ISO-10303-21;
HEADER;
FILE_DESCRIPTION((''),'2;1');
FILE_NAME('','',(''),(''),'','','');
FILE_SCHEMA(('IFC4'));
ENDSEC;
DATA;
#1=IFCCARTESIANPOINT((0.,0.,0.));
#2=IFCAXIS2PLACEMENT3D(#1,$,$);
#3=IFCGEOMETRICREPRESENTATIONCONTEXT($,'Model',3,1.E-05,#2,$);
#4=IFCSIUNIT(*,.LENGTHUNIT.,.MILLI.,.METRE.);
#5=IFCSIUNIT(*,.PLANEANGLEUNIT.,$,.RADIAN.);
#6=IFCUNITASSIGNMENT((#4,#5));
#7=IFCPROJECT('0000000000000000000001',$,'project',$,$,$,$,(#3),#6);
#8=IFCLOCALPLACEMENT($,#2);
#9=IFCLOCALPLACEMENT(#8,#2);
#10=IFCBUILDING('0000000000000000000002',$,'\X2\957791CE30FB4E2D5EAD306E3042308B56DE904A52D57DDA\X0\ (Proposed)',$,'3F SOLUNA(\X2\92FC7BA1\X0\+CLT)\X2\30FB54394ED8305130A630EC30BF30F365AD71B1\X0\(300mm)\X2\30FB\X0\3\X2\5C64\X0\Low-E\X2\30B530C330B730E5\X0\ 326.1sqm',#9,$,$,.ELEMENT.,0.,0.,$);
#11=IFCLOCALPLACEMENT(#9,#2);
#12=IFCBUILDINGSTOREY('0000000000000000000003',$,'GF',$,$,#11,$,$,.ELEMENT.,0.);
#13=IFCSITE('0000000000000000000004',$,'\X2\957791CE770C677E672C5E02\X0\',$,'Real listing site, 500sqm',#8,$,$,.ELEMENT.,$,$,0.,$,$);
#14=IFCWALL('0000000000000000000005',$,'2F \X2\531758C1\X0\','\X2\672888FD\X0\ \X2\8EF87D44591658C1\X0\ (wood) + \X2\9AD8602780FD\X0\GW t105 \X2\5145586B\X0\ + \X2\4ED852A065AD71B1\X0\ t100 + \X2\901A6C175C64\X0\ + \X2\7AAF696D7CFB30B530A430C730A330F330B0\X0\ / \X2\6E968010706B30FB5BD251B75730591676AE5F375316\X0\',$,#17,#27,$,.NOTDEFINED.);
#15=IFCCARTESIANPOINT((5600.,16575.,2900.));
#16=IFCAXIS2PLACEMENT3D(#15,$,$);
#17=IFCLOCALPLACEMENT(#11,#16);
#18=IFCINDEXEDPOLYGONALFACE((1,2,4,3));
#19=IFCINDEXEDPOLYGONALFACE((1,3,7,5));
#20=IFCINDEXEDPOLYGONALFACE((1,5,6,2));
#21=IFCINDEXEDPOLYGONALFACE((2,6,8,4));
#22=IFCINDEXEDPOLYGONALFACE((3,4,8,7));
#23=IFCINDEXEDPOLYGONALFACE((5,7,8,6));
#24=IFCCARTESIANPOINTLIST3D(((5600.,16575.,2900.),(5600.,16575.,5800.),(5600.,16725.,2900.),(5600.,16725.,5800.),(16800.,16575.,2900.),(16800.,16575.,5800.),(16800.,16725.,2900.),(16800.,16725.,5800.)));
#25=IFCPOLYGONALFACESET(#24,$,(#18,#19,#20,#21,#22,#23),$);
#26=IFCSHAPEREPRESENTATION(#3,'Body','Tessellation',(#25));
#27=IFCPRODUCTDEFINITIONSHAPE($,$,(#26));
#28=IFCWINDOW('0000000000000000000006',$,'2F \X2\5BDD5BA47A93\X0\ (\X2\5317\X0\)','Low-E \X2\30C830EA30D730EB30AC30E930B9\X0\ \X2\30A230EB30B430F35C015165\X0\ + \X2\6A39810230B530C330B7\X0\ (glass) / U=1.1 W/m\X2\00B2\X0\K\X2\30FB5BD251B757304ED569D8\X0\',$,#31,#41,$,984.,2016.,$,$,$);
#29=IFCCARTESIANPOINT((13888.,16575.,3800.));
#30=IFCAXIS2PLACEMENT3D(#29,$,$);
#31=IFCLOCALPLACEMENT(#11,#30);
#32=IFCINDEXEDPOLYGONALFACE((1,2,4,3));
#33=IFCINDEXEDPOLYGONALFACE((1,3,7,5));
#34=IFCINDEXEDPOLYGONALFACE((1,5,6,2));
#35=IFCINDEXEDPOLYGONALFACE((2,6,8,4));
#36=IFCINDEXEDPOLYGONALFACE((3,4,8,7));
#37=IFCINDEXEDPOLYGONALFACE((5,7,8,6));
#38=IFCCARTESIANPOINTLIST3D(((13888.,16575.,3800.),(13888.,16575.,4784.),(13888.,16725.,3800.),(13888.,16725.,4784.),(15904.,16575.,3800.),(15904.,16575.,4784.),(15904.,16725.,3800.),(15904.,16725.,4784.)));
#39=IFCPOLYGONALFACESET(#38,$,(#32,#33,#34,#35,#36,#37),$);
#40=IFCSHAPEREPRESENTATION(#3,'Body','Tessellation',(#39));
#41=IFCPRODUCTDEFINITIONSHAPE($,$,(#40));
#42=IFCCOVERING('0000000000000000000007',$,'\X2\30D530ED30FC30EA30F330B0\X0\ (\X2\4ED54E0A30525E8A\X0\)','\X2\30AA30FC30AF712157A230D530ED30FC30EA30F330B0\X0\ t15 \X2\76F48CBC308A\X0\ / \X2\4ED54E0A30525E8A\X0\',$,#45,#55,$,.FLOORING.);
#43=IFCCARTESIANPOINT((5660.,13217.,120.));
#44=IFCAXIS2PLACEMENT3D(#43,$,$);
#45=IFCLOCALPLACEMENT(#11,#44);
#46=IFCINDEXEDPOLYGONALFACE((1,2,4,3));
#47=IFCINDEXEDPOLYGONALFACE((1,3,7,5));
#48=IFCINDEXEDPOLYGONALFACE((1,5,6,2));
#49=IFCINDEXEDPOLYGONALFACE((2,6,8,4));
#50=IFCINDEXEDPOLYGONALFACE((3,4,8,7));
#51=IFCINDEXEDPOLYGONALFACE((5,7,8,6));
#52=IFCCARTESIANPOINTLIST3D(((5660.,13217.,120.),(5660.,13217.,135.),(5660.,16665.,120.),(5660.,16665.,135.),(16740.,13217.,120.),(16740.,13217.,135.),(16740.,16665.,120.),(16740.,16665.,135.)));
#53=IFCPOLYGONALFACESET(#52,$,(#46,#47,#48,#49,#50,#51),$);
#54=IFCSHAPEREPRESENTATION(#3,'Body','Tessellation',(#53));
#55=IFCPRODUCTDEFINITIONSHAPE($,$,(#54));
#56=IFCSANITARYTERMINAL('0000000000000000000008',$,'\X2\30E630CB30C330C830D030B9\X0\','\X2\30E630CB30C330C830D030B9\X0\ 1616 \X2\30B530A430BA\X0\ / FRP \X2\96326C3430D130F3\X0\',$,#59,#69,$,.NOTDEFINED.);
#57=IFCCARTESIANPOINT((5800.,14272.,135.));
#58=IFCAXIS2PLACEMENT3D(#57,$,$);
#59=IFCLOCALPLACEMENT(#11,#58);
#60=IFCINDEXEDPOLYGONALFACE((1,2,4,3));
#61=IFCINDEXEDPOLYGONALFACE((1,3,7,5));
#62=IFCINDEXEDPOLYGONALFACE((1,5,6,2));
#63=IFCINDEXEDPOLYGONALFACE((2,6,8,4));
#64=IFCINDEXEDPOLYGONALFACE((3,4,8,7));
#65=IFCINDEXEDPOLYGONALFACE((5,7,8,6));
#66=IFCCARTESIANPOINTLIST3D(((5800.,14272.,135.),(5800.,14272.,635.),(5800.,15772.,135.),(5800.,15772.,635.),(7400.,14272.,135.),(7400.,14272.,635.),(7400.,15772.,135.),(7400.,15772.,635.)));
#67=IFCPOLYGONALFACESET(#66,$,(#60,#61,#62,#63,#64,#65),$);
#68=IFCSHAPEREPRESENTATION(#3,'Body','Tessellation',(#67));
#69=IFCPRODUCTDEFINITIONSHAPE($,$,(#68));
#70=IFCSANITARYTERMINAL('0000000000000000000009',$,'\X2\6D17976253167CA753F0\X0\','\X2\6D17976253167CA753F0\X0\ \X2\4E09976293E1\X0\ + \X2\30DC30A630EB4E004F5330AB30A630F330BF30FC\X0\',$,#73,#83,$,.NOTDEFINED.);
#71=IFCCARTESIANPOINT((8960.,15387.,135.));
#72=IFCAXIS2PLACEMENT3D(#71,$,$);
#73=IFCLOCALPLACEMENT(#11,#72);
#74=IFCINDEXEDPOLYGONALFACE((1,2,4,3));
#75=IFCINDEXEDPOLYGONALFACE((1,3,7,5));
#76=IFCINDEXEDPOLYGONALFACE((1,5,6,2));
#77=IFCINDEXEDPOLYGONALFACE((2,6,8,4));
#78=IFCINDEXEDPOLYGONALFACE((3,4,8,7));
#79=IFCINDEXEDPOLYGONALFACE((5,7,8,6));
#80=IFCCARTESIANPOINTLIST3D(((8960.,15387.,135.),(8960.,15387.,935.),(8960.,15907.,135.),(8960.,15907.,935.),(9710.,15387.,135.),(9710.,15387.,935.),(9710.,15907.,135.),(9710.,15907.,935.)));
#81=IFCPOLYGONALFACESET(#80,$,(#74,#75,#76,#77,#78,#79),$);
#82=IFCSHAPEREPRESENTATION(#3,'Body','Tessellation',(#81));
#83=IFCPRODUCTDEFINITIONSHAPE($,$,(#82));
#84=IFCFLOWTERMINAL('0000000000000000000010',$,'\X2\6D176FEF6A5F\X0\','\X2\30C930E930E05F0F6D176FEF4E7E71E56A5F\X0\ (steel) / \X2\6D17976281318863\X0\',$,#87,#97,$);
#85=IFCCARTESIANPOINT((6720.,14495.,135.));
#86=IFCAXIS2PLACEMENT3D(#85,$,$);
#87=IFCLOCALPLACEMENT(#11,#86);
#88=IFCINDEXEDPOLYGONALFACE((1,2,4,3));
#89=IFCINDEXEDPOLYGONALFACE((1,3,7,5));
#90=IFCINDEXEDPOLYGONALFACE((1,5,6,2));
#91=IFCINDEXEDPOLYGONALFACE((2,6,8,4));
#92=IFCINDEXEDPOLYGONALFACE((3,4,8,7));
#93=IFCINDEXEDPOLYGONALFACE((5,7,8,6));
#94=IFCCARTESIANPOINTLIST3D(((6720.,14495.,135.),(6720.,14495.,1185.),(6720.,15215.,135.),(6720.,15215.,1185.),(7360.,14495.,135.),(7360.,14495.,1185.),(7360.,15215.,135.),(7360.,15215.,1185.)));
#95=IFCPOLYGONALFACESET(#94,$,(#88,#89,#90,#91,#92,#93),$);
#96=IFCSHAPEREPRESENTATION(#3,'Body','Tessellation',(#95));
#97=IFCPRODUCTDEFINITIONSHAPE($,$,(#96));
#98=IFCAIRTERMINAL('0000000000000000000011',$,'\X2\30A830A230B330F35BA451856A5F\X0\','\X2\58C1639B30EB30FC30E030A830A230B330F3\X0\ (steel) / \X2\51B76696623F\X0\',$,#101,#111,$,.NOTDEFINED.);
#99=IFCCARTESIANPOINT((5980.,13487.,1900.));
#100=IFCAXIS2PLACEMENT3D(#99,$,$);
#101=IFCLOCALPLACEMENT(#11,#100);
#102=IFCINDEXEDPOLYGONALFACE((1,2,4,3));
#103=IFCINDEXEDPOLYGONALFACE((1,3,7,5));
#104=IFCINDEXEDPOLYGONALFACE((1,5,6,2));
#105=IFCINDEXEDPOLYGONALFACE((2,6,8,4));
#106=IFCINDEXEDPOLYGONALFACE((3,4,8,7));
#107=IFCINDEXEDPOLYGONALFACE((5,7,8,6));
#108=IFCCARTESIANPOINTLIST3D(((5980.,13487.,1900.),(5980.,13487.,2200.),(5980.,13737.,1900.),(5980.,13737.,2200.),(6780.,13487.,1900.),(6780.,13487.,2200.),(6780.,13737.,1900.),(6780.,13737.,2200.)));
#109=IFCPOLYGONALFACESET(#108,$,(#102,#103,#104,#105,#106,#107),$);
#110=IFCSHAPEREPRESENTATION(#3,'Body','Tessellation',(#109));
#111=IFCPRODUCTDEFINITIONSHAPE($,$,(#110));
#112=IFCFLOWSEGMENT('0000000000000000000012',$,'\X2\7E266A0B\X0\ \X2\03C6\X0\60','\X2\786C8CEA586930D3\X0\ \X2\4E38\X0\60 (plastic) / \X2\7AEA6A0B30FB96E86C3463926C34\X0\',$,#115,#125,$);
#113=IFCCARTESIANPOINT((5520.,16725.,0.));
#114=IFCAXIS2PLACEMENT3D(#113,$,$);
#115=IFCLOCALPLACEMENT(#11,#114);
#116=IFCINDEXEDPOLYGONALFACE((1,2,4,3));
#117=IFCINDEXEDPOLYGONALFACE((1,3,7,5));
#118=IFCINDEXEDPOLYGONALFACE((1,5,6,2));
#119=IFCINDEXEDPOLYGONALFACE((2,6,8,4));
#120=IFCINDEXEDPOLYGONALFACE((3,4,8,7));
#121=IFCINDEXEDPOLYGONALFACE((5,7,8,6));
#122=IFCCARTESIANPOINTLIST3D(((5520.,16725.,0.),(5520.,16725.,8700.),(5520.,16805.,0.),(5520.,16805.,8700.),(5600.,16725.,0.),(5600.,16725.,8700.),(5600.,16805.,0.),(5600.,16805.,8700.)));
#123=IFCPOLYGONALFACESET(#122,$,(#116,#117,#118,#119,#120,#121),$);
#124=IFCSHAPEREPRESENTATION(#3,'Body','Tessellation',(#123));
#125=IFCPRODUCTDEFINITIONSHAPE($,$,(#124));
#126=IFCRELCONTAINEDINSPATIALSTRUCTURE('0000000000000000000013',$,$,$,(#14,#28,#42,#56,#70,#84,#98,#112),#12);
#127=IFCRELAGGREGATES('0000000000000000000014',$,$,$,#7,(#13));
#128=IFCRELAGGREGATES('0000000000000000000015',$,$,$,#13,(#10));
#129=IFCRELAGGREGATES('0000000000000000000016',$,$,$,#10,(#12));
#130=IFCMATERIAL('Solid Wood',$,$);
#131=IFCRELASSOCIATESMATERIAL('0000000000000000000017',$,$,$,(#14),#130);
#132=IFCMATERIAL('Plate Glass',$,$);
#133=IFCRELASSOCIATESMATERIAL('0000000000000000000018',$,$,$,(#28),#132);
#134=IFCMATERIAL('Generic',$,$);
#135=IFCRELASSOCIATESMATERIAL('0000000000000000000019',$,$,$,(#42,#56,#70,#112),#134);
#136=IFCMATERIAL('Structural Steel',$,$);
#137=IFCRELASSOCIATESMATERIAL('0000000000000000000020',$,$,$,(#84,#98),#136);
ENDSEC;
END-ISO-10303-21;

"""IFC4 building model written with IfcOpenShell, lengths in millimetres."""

from ifc_helpers import new_model, si_unit, frame, frame_2d, origin, place, context, project, spatial, rectangle, extrude, material, element, fill, save


model = new_model("IFC4")

# Units and contexts
model_context = context("Model", 3, precision=1e-05, world=origin())
ifc_project = project(units=[si_unit("LENGTHUNIT", "METRE", prefix="MILLI"), si_unit("PLANEANGLEUNIT", "RADIAN")], contexts=[model_context])

# Site, building, storey
site_placement = place(None, origin())
site = spatial("IfcSite", under=ifc_project, at=site_placement, Name="長野県松本市", ObjectType="Real listing site, 500sqm", CompositionType="ELEMENT", RefElevation=0.0)
building_placement = place(site_placement, origin())
building = spatial("IfcBuilding", under=site, at=building_placement, Name="長野・中庭のある回遊動線 (Proposed)", ObjectType="3F SOLUNA(鋼管+CLT)・吹付けウレタン断熱(300mm)・3層Low-Eサッシュ 326.1sqm", CompositionType="ELEMENT", ElevationOfRefHeight=0.0, ElevationOfTerrain=0.0)
storey_placement = place(building_placement, origin())
storey = spatial("IfcBuildingStorey", under=building, at=storey_placement, Name="GF", CompositionType="ELEMENT", Elevation=0.0)

# Shared definitions
ifc_material_1 = material(Name="Solid Wood")

# Shared definitions
ifc_material_2 = material(Name="Plate Glass")

# Wall, opening, window
wall_1_placement = place(storey_placement, frame((5600.0, 16575.0, 2900.0)))
wall_1 = element("IfcWall", 1, at=wall_1_placement, inside=storey, material=ifc_material_1, Name="2F 北壁", Description="木製 軸組外壁 (wood) + 高性能GW t105 充填 + 付加断熱 t100 + 通気層 + 窯業系サイディング / 準耐火・寒冷地外皮強化", PredefinedType="NOTDEFINED", context=model_context, shape_type="SweptSolid", body=[
    extrude(rectangle(XDim=11200.0, YDim=150.0, at=frame_2d((5600.0, 75.0))), frame((5600.0, 16575.0, 2900.0)), (0.0, 0.0, 1.0), 2900.0),
])
opening_1_placement = place(storey_placement, frame((13888.0, 16575.0, 3800.0)))
opening_1 = element("IfcOpeningElement", 2, at=opening_1_placement, cuts=wall_1, PredefinedType="NOTDEFINED", context=model_context, shape_type="SweptSolid", body=[
    extrude(rectangle(XDim=2016.0, YDim=150.0, at=frame_2d((1008.0, 75.0))), frame((13888.0, 16575.0, 3800.0)), (0.0, 0.0, 1.0), 984.0),
])
window_1_placement = place(storey_placement, frame((13888.0, 16575.0, 3800.0)))
window_1 = element("IfcWindow", 3, at=window_1_placement, inside=storey, material=ifc_material_2, Name="2F 寝室窓 (北)", Description="Low-E トリプルガラス アルゴン封入 + 樹脂サッシ (glass) / U=1.1 W/m²K・寒冷地仕様", OverallHeight=984.0, OverallWidth=2016.0, context=model_context, shape_type="SweptSolid", body=[
    extrude(rectangle(XDim=2016.0, YDim=150.0, at=frame_2d((1008.0, 75.0))), frame((13888.0, 16575.0, 3800.0)), (0.0, 0.0, 1.0), 984.0),
])
fill(opening_1, window_1)

# Covering
ifc_material_3 = material(Name="Generic")
covering_placement = place(storey_placement, frame((5660.0, 13217.0, 120.0)))
element("IfcCovering", 4, at=covering_placement, inside=storey, material=ifc_material_3, Name="フローリング (仕上げ床)", Description="オーク無垢フローリング t15 直貼り / 仕上げ床", PredefinedType="FLOORING", context=model_context, shape_type="SweptSolid", body=[
    extrude(rectangle(XDim=11080.0, YDim=3448.0, at=frame_2d((5540.0, 1724.0))), frame((5660.0, 13217.0, 120.0)), (0.0, 0.0, 1.0), 15.0),
])

# Sanitary terminals
sanitary_terminal_1_placement = place(storey_placement, frame((5800.0, 14272.0, 135.0)))
element("IfcSanitaryTerminal", 5, at=sanitary_terminal_1_placement, inside=storey, material=ifc_material_3, Name="ユニットバス", Description="ユニットバス 1616 サイズ / FRP 防水パン", PredefinedType="NOTDEFINED", context=model_context, shape_type="SweptSolid", body=[
    extrude(rectangle(XDim=1600.0, YDim=1500.0, at=frame_2d((800.0, 750.0))), frame((5800.0, 14272.0, 135.0)), (0.0, 0.0, 1.0), 500.0),
])
sanitary_terminal_2_placement = place(storey_placement, frame((8960.0, 15387.0, 135.0)))
element("IfcSanitaryTerminal", 6, at=sanitary_terminal_2_placement, inside=storey, material=ifc_material_3, Name="洗面化粧台", Description="洗面化粧台 三面鏡 + ボウル一体カウンター", PredefinedType="NOTDEFINED", context=model_context, shape_type="SweptSolid", body=[
    extrude(rectangle(XDim=750.0, YDim=520.0, at=frame_2d((375.0, 260.0))), frame((8960.0, 15387.0, 135.0)), (0.0, 0.0, 1.0), 800.0),
])

# Flow terminal
ifc_material_4 = material(Name="Structural Steel")
flow_terminal_placement = place(storey_placement, frame((6720.0, 14495.0, 135.0)))
element("IfcFlowTerminal", 7, at=flow_terminal_placement, inside=storey, material=ifc_material_4, Name="洗濯機", Description="ドラム式洗濯乾燥機 (steel) / 洗面脱衣", context=model_context, shape_type="SweptSolid", body=[
    extrude(rectangle(XDim=640.0, YDim=720.0, at=frame_2d((320.0, 360.0))), frame((6720.0, 14495.0, 135.0)), (0.0, 0.0, 1.0), 1050.0),
])

# Air terminal
air_terminal_placement = place(storey_placement, frame((5980.0, 13487.0, 1900.0)))
element("IfcAirTerminal", 8, at=air_terminal_placement, inside=storey, material=ifc_material_4, Name="エアコン室内機", Description="壁掛ルームエアコン (steel) / 冷暖房", PredefinedType="NOTDEFINED", context=model_context, shape_type="SweptSolid", body=[
    extrude(rectangle(XDim=800.0, YDim=250.0, at=frame_2d((400.0, 125.0))), frame((5980.0, 13487.0, 1900.0)), (0.0, 0.0, 1.0), 300.0),
])

# Flow segment
flow_segment_placement = place(storey_placement, frame((5520.0, 16725.0, 0.0)))
element("IfcFlowSegment", 9, at=flow_segment_placement, inside=storey, material=ifc_material_3, Name="縦樋 φ60", Description="硬質塩ビ 丸60 (plastic) / 竪樋・雨水排水", context=model_context, shape_type="SweptSolid", body=[
    extrude(rectangle(XDim=80.0, YDim=80.0, at=frame_2d((40.0, 40.0))), frame((5520.0, 16725.0, 0.0)), (0.0, 0.0, 1.0), 8700.0),
])

save(model, "model.ifc")
